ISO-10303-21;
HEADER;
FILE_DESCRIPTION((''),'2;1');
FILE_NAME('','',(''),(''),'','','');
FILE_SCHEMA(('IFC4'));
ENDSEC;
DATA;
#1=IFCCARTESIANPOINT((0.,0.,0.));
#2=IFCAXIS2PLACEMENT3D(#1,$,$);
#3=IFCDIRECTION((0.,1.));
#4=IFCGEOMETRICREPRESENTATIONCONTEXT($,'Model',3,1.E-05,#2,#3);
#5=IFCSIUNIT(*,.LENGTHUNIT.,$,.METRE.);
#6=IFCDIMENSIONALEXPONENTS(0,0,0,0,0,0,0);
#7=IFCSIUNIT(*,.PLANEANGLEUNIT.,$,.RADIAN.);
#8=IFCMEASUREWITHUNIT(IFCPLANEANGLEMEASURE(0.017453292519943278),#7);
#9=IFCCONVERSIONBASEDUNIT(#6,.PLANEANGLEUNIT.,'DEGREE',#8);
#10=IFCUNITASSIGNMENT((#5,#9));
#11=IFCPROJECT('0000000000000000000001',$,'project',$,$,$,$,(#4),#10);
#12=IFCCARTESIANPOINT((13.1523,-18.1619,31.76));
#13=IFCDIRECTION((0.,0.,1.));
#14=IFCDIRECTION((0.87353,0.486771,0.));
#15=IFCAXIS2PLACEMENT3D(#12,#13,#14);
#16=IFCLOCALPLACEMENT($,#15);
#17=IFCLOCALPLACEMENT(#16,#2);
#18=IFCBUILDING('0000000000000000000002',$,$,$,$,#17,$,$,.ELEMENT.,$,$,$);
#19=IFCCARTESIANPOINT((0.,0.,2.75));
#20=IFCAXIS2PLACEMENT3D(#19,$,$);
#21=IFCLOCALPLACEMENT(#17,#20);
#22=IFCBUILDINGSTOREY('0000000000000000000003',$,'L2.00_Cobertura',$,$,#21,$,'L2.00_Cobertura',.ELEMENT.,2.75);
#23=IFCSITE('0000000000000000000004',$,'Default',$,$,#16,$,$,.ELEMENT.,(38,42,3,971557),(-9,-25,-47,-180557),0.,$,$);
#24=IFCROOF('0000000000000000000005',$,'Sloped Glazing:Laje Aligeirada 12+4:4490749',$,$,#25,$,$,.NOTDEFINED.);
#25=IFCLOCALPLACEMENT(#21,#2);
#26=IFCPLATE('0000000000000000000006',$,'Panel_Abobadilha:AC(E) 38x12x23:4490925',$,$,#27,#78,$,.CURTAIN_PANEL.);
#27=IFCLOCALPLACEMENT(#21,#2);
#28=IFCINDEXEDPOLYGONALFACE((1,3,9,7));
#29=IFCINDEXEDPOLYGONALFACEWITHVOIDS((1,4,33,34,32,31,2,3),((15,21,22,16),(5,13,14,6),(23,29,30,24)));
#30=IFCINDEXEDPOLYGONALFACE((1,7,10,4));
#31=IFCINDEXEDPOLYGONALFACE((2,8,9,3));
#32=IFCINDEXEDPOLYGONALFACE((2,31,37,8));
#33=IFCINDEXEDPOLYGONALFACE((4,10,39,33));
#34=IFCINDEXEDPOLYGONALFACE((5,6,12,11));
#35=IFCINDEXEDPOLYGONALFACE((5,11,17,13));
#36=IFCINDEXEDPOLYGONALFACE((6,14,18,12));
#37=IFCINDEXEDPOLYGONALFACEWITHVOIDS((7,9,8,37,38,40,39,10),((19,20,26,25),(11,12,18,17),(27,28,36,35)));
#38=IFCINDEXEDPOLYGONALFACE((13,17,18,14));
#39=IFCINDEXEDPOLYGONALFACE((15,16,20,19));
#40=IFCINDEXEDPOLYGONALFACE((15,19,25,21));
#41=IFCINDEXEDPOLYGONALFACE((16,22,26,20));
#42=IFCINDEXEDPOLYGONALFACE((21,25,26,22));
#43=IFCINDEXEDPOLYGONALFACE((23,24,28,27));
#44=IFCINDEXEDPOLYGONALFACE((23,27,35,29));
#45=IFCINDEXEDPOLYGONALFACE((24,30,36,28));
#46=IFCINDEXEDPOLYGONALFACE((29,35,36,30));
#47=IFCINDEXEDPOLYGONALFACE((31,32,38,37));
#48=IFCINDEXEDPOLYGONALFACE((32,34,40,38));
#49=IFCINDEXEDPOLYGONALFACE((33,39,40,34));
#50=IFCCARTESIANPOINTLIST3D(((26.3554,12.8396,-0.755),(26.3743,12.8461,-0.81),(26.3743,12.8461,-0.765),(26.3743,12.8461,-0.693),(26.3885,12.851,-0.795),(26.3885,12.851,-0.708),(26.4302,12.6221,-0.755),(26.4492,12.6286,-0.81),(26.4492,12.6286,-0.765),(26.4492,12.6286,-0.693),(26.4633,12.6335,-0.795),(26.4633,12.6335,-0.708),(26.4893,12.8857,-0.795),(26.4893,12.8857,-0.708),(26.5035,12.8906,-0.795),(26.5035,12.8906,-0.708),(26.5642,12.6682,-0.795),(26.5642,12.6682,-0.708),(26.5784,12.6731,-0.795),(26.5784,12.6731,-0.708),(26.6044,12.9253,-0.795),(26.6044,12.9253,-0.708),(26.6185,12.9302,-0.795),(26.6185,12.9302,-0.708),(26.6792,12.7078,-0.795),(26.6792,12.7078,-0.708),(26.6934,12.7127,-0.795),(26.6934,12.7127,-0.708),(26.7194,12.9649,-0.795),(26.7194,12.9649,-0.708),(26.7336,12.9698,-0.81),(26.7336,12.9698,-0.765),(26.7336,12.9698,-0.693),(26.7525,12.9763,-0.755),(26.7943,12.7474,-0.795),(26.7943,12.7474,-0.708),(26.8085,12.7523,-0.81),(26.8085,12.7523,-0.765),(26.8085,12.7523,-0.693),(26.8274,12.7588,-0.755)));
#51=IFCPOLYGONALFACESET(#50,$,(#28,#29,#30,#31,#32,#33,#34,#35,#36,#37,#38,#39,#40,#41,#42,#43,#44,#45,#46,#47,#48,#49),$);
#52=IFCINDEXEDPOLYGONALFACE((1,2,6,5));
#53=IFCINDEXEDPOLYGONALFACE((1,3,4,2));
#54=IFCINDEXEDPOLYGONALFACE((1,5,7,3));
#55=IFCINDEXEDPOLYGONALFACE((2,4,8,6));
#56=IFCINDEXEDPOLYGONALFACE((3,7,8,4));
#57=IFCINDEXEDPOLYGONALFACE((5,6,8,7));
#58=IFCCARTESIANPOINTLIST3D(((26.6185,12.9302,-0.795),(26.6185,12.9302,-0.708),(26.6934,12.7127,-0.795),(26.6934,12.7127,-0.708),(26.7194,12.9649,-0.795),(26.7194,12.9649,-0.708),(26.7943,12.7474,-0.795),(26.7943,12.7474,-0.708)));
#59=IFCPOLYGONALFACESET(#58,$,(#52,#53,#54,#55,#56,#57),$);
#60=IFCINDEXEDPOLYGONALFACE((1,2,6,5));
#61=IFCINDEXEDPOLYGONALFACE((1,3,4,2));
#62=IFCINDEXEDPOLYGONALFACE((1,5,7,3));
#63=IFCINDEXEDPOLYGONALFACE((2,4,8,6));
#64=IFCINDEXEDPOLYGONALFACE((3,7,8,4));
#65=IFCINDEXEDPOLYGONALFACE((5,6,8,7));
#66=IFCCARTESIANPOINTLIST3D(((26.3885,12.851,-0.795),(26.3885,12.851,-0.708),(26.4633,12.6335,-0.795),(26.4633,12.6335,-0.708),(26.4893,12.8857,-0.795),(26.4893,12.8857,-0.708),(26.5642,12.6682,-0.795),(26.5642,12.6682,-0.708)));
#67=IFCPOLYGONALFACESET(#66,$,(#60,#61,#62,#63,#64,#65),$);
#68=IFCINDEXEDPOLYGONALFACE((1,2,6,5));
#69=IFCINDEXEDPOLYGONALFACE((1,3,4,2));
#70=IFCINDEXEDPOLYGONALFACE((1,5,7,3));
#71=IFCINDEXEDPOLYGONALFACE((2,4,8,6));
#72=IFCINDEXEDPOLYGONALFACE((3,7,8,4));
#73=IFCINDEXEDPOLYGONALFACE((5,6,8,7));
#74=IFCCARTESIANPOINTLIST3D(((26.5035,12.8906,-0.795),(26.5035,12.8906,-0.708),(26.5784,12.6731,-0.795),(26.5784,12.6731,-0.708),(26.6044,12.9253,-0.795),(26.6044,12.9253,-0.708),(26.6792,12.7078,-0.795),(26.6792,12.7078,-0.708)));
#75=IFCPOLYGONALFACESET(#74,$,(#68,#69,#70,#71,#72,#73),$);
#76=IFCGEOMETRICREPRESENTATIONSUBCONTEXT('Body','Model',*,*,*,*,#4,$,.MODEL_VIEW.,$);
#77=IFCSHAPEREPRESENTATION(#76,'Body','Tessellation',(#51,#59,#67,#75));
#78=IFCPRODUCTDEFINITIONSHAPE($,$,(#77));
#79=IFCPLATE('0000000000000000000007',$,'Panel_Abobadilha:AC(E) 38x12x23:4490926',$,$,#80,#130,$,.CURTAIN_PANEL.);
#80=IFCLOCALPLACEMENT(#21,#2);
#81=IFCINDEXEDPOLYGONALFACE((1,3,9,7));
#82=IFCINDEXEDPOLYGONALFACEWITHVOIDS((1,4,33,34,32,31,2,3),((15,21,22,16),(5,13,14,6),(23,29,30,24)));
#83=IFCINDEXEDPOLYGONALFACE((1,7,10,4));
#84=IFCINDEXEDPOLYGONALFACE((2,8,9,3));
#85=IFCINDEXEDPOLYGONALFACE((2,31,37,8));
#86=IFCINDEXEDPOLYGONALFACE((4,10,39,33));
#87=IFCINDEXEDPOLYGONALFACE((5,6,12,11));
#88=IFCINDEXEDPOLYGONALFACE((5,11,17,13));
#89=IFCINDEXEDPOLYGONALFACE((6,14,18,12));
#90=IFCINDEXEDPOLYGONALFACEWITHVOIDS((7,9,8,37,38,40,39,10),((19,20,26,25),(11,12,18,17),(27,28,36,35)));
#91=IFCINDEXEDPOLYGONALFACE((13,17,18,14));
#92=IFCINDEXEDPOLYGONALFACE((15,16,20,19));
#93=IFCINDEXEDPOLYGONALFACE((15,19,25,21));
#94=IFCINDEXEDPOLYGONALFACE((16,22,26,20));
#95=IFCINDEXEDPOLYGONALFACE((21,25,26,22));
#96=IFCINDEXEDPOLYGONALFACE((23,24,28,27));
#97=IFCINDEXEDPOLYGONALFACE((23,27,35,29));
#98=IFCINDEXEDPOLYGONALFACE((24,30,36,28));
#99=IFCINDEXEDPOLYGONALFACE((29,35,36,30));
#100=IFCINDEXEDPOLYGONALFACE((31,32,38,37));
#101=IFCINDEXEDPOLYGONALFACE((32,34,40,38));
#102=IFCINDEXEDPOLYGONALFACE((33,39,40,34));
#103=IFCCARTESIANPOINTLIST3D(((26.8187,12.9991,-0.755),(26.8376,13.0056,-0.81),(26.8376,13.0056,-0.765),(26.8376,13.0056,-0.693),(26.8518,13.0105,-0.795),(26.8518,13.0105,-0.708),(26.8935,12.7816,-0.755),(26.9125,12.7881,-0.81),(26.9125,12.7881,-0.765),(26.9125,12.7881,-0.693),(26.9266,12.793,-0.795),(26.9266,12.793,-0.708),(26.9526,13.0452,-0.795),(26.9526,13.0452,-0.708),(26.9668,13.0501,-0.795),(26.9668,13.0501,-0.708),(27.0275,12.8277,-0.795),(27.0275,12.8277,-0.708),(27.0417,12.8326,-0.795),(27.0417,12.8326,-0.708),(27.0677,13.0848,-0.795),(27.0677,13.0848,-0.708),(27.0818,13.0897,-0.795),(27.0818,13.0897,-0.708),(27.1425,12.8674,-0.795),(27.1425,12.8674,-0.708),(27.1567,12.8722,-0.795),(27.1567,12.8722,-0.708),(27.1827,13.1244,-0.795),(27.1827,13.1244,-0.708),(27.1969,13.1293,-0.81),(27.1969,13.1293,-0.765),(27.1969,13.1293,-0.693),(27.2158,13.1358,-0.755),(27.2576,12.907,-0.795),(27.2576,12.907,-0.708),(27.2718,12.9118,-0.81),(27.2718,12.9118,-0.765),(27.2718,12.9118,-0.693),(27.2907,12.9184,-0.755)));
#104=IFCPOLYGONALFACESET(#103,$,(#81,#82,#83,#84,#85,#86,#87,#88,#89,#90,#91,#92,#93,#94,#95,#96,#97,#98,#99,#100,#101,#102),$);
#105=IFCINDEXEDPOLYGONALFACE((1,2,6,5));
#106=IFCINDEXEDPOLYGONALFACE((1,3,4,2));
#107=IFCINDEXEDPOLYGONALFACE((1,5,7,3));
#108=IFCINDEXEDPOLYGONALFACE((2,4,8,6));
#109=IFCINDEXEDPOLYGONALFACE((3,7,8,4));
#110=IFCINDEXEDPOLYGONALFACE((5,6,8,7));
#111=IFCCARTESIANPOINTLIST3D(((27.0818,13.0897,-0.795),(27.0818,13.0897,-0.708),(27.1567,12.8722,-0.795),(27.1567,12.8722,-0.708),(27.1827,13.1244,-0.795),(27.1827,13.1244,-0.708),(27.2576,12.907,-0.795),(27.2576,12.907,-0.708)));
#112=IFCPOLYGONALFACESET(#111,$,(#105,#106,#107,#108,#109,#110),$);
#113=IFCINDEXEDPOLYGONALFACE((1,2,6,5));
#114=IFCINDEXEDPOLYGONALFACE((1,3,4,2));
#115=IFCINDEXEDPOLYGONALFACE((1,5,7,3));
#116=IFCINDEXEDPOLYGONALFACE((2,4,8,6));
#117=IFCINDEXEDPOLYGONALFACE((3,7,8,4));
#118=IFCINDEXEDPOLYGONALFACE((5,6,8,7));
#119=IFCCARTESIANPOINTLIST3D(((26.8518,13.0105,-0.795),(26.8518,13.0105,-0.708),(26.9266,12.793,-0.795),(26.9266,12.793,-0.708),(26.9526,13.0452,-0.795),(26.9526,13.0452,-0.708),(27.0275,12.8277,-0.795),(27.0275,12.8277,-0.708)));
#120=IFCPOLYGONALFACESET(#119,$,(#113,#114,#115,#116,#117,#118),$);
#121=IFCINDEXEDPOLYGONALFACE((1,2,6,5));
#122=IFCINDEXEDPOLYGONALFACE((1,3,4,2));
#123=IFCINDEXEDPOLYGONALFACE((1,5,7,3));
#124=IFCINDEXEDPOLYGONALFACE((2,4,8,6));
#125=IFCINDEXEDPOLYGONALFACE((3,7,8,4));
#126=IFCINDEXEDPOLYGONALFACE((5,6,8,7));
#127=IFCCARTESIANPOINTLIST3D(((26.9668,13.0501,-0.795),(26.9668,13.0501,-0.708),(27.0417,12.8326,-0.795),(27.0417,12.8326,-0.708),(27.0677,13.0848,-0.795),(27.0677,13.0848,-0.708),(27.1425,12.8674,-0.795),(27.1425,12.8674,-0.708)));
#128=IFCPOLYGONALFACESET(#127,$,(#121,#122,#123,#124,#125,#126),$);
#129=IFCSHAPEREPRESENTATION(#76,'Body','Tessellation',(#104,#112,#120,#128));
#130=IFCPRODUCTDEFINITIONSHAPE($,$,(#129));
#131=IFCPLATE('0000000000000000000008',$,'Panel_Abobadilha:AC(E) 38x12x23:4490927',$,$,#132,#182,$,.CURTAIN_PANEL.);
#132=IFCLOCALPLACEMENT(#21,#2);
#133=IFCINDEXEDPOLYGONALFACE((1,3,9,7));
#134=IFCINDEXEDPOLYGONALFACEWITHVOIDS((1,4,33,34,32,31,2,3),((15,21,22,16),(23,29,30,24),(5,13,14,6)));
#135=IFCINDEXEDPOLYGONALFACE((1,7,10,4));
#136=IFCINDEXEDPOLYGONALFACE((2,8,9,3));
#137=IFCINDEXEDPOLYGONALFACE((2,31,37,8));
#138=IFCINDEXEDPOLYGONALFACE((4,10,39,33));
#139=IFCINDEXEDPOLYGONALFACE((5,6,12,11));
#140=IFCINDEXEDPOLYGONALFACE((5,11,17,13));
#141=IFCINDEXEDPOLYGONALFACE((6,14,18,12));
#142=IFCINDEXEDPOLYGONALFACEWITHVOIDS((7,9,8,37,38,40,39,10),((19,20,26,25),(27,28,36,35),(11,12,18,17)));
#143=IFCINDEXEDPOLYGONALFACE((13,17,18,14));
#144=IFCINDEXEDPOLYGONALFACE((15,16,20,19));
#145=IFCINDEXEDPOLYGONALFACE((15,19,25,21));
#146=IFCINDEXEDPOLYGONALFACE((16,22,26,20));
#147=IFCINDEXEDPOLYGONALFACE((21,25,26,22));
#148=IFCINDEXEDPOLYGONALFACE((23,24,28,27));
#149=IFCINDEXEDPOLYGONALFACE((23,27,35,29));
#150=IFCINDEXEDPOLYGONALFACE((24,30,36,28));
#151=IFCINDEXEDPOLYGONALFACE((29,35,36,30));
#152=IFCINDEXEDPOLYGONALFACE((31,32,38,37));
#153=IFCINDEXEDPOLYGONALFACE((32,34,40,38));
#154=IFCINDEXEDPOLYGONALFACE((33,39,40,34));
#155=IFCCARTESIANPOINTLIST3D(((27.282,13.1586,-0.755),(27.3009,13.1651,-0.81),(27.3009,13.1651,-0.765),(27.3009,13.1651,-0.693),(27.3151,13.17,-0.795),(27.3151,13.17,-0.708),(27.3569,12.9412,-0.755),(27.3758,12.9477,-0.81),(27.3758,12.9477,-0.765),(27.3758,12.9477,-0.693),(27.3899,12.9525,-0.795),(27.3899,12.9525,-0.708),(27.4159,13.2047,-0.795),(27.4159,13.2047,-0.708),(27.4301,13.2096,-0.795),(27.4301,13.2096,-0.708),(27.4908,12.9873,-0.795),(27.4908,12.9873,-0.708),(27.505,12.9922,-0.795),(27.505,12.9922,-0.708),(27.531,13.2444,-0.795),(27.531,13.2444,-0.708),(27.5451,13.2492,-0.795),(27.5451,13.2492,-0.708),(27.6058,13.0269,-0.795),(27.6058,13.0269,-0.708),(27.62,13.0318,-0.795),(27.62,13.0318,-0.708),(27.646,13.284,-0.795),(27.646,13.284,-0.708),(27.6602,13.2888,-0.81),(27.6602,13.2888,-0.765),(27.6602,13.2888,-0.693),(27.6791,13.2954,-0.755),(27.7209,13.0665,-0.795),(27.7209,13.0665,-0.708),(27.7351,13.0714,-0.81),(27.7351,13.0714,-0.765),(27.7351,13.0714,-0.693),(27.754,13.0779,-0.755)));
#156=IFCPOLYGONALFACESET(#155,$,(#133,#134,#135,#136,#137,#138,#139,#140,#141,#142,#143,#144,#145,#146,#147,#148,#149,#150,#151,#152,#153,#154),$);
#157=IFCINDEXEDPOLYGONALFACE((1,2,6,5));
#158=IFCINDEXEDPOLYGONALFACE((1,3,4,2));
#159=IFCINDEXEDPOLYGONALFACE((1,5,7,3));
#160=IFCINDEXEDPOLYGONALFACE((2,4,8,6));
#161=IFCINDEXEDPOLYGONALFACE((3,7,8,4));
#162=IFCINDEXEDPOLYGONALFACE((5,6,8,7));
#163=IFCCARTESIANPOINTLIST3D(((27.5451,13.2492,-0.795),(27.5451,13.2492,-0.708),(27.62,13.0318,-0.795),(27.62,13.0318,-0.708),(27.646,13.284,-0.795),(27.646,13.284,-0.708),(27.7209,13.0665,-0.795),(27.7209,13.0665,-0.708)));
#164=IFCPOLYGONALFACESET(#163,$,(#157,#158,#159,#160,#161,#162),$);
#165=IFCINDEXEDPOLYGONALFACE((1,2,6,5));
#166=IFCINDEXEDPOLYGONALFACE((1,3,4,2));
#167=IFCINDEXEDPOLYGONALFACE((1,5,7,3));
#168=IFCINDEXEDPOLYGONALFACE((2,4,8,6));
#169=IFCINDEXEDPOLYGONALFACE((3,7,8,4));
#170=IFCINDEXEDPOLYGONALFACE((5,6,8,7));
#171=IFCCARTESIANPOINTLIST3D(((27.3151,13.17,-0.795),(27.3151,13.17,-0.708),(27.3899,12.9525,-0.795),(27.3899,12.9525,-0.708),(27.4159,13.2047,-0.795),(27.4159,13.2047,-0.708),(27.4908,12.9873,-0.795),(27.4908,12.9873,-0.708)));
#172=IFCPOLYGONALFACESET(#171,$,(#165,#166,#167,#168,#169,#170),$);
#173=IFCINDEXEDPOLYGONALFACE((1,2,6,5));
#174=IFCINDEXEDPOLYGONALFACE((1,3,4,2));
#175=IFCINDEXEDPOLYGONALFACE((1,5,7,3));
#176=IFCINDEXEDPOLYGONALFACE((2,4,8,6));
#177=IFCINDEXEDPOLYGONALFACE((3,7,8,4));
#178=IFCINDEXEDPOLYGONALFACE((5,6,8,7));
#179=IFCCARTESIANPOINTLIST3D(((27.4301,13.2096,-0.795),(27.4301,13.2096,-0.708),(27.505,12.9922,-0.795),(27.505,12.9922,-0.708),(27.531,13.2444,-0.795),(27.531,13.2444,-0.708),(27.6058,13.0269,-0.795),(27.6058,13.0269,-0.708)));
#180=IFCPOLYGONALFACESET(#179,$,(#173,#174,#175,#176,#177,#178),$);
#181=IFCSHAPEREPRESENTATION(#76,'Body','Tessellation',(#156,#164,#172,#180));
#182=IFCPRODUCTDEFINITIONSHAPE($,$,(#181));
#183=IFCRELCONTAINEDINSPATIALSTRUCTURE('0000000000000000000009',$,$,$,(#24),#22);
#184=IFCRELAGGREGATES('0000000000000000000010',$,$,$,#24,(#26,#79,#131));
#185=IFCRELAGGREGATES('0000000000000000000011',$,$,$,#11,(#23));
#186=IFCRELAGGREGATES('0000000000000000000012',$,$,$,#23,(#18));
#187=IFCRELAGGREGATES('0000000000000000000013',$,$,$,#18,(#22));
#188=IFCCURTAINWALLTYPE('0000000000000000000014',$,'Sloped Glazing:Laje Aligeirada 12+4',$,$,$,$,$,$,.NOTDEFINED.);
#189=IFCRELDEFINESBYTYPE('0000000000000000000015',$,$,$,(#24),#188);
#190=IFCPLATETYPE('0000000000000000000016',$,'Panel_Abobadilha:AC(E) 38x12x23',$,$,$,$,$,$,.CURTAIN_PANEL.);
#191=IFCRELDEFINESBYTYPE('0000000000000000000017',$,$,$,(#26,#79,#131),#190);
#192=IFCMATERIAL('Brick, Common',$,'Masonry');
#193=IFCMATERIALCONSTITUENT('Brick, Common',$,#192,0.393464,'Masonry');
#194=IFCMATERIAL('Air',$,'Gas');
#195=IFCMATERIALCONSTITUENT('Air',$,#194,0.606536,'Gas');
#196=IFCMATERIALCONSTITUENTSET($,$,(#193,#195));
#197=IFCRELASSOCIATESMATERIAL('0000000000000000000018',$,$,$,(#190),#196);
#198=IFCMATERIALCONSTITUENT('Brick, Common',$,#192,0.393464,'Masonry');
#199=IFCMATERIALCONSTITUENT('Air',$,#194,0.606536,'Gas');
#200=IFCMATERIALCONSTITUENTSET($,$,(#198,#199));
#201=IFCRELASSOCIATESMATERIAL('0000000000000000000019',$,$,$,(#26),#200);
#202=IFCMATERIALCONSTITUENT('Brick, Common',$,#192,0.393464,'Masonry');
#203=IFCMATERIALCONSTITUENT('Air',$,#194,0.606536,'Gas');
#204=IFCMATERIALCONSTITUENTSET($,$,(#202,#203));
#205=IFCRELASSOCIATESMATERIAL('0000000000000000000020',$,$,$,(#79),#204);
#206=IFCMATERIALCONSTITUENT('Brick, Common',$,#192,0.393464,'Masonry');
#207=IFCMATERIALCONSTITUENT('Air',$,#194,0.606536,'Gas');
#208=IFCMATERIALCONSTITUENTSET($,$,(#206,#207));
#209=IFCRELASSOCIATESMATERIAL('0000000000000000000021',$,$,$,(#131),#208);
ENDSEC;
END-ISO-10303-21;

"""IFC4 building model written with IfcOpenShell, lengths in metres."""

from ifc_helpers import new_model, entity, si_unit, converted_unit, direction, frame, origin, place, context, subcontext, project, spatial, indexed_curve, outline, extrude, source, transform, mapped, material, constituent, constituent_set, type_object, type_shapes, element, aggregate, save


model = new_model("IFC4")

# Units and contexts
model_context = context("Model", 3, precision=1e-05, world=origin(), true_north=direction((0.0, 1.0)))
body_context = subcontext(model_context, "Body", "Model", "MODEL_VIEW")
ifc_project = project(units=[si_unit("LENGTHUNIT", "METRE"), converted_unit("PLANEANGLEUNIT", "DEGREE", entity("IfcPlaneAngleMeasure", 0.017453292519943278), si_unit("PLANEANGLEUNIT", "RADIAN"), dimensions=[0, 0, 0, 0, 0, 0, 0])], contexts=[model_context])

# Site, building, storey
site_placement = place(None, frame((13.1523, -18.1619, 31.76), z_axis=(0.0, 0.0, 1.0), x_axis=(0.87353, 0.486771, 0.0)))
site = spatial("IfcSite", under=ifc_project, at=site_placement, Name="Default", CompositionType="ELEMENT", RefLatitude=(38, 42, 3, 971557), RefLongitude=(-9, -25, -47, -180557), RefElevation=0.0)
building_placement = place(site_placement, origin())
building = spatial("IfcBuilding", under=site, at=building_placement, CompositionType="ELEMENT")
storey_placement = place(building_placement, frame((0.0, 0.0, 2.75)))
storey = spatial("IfcBuildingStorey", under=building, at=storey_placement, Name="L2.00_Cobertura", LongName="L2.00_Cobertura", CompositionType="ELEMENT", Elevation=2.75)

# Roof, plates
curtain_wall_type = type_object("IfcCurtainWallType", Name="Sloped Glazing:Laje Aligeirada 12+4", PredefinedType="NOTDEFINED")
roof_placement = place(storey_placement, frame((0.0, 0.0, -2.75)))
roof = element("IfcRoof", 1, at=roof_placement, inside=storey, type_object=curtain_wall_type, Name="Sloped Glazing:Laje Aligeirada 12+4:4490749", PredefinedType="NOTDEFINED")
ifc_material_1 = material(Name="Brick, Common", Category="Masonry")
ifc_material_2 = material(Name="Air", Category="Gas")
ifc_constituent_1 = constituent(ifc_material_1, Name="Brick, Common", Category="Masonry", fraction=0.393464)
ifc_constituent_2 = constituent(ifc_material_2, Name="Air", Category="Gas", fraction=0.606536)
ifc_constituent_set_1 = constituent_set(constituents=[ifc_constituent_1, ifc_constituent_2])
plate_type = type_object("IfcPlateType", Name="Panel_Abobadilha:AC(E) 38x12x23", PredefinedType="CURTAIN_PANEL", material=ifc_constituent_set_1)
shared_shape_1 = source(origin(), body_context, "Body", "SweptSolid", [
    extrude(outline(indexed_curve([(-0.19, -0.0543), (0.19, -0.0543), (0.19, -0.0093), (0.21, 0.0007), (0.19, 0.0628), (-0.19, 0.0628), (-0.21, 0.0007), (-0.19, -0.0093), (-0.19, -0.0543)], self_intersect=False), holes=[indexed_curve([(-0.0683, 0.0477), (-0.0683, -0.0393), (-0.175, -0.0393), (-0.175, 0.0477), (-0.0683, 0.0477)], self_intersect=False), indexed_curve([(0.0533, 0.0477), (0.0533, -0.0393), (-0.0533, -0.0393), (-0.0533, 0.0477), (0.0533, 0.0477)], self_intersect=False), indexed_curve([(0.175, 0.0477), (0.175, -0.0393), (0.0683, -0.0393), (0.0683, 0.0477), (0.175, 0.0477)], self_intersect=False)]), frame((0.0, 0.0543, 0.0)), (0.0, 0.0, 1.0), 0.23),
    extrude(outline(indexed_curve([(-0.0533, -0.0435), (0.0533, -0.0435), (0.0533, 0.0435), (-0.0533, 0.0435), (-0.0533, -0.0435)], self_intersect=False)), frame((0.1217, 0.0585, 0.0), z_axis=(0.0, 0.0, 1.0), x_axis=(-1.0, 0.0, 0.0)), (0.0, 0.0, 1.0), 0.23),
    extrude(outline(indexed_curve([(-0.0533, -0.0435), (0.0533, -0.0435), (0.0533, 0.0435), (-0.0533, 0.0435), (-0.0533, -0.0435)], self_intersect=False)), frame((-0.1217, 0.0585, 0.0), z_axis=(0.0, 0.0, 1.0), x_axis=(-1.0, 0.0, 0.0)), (0.0, 0.0, 1.0), 0.23),
    extrude(outline(indexed_curve([(-0.0533, -0.0435), (0.0533, -0.0435), (0.0533, 0.0435), (-0.0533, 0.0435), (-0.0533, -0.0435)], self_intersect=False)), frame((0.0, 0.0585, 0.0), z_axis=(0.0, 0.0, 1.0), x_axis=(-1.0, 0.0, 0.0)), (0.0, 0.0, 1.0), 0.23),
])
type_shapes(plate_type, [shared_shape_1])
ifc_constituent_3 = constituent(ifc_material_1, Name="Brick, Common", Category="Masonry", fraction=0.393464)
ifc_constituent_4 = constituent(ifc_material_2, Name="Air", Category="Gas", fraction=0.606536)
ifc_constituent_set_2 = constituent_set(constituents=[ifc_constituent_3, ifc_constituent_4])
plate_1_placement = place(roof_placement, frame((26.5539, 12.9079, 1.94), z_axis=(0.325568, -0.945519, 0.0), x_axis=(0.945519, 0.325568, 0.0)))
plate_1 = element("IfcPlate", 2, at=plate_1_placement, type_object=plate_type, material=ifc_constituent_set_2, Name="Panel_Abobadilha:AC(E) 38x12x23:4490925", PredefinedType="CURTAIN_PANEL", context=body_context, shape_type="MappedRepresentation", body=[
    mapped(shared_shape_1, transform((0.0, 0.0, 0.0), scale=1.0)),
])
ifc_constituent_5 = constituent(ifc_material_1, Name="Brick, Common", Category="Masonry", fraction=0.393464)
ifc_constituent_6 = constituent(ifc_material_2, Name="Air", Category="Gas", fraction=0.606536)
ifc_constituent_set_3 = constituent_set(constituents=[ifc_constituent_5, ifc_constituent_6])
plate_2_placement = place(roof_placement, frame((27.0172, 13.0675, 1.94), z_axis=(0.325568, -0.945519, 0.0), x_axis=(0.945519, 0.325568, 0.0)))
plate_2 = element("IfcPlate", 3, at=plate_2_placement, type_object=plate_type, material=ifc_constituent_set_3, Name="Panel_Abobadilha:AC(E) 38x12x23:4490926", PredefinedType="CURTAIN_PANEL", context=body_context, shape_type="MappedRepresentation", body=[
    mapped(shared_shape_1, transform((0.0, 0.0, 0.0), scale=1.0)),
])
ifc_constituent_7 = constituent(ifc_material_1, Name="Brick, Common", Category="Masonry", fraction=0.393464)
ifc_constituent_8 = constituent(ifc_material_2, Name="Air", Category="Gas", fraction=0.606536)
ifc_constituent_set_4 = constituent_set(constituents=[ifc_constituent_7, ifc_constituent_8])
plate_3_placement = place(roof_placement, frame((27.4805, 13.227, 1.94), z_axis=(0.325568, -0.945519, 0.0), x_axis=(0.945519, 0.325568, 0.0)))
plate_3 = element("IfcPlate", 4, at=plate_3_placement, type_object=plate_type, material=ifc_constituent_set_4, Name="Panel_Abobadilha:AC(E) 38x12x23:4490927", PredefinedType="CURTAIN_PANEL", context=body_context, shape_type="MappedRepresentation", body=[
    mapped(shared_shape_1, transform((0.0, 0.0, 0.0), scale=1.0)),
])
aggregate(roof, [plate_1, plate_2, plate_3])

save(model, "model.ifc")
